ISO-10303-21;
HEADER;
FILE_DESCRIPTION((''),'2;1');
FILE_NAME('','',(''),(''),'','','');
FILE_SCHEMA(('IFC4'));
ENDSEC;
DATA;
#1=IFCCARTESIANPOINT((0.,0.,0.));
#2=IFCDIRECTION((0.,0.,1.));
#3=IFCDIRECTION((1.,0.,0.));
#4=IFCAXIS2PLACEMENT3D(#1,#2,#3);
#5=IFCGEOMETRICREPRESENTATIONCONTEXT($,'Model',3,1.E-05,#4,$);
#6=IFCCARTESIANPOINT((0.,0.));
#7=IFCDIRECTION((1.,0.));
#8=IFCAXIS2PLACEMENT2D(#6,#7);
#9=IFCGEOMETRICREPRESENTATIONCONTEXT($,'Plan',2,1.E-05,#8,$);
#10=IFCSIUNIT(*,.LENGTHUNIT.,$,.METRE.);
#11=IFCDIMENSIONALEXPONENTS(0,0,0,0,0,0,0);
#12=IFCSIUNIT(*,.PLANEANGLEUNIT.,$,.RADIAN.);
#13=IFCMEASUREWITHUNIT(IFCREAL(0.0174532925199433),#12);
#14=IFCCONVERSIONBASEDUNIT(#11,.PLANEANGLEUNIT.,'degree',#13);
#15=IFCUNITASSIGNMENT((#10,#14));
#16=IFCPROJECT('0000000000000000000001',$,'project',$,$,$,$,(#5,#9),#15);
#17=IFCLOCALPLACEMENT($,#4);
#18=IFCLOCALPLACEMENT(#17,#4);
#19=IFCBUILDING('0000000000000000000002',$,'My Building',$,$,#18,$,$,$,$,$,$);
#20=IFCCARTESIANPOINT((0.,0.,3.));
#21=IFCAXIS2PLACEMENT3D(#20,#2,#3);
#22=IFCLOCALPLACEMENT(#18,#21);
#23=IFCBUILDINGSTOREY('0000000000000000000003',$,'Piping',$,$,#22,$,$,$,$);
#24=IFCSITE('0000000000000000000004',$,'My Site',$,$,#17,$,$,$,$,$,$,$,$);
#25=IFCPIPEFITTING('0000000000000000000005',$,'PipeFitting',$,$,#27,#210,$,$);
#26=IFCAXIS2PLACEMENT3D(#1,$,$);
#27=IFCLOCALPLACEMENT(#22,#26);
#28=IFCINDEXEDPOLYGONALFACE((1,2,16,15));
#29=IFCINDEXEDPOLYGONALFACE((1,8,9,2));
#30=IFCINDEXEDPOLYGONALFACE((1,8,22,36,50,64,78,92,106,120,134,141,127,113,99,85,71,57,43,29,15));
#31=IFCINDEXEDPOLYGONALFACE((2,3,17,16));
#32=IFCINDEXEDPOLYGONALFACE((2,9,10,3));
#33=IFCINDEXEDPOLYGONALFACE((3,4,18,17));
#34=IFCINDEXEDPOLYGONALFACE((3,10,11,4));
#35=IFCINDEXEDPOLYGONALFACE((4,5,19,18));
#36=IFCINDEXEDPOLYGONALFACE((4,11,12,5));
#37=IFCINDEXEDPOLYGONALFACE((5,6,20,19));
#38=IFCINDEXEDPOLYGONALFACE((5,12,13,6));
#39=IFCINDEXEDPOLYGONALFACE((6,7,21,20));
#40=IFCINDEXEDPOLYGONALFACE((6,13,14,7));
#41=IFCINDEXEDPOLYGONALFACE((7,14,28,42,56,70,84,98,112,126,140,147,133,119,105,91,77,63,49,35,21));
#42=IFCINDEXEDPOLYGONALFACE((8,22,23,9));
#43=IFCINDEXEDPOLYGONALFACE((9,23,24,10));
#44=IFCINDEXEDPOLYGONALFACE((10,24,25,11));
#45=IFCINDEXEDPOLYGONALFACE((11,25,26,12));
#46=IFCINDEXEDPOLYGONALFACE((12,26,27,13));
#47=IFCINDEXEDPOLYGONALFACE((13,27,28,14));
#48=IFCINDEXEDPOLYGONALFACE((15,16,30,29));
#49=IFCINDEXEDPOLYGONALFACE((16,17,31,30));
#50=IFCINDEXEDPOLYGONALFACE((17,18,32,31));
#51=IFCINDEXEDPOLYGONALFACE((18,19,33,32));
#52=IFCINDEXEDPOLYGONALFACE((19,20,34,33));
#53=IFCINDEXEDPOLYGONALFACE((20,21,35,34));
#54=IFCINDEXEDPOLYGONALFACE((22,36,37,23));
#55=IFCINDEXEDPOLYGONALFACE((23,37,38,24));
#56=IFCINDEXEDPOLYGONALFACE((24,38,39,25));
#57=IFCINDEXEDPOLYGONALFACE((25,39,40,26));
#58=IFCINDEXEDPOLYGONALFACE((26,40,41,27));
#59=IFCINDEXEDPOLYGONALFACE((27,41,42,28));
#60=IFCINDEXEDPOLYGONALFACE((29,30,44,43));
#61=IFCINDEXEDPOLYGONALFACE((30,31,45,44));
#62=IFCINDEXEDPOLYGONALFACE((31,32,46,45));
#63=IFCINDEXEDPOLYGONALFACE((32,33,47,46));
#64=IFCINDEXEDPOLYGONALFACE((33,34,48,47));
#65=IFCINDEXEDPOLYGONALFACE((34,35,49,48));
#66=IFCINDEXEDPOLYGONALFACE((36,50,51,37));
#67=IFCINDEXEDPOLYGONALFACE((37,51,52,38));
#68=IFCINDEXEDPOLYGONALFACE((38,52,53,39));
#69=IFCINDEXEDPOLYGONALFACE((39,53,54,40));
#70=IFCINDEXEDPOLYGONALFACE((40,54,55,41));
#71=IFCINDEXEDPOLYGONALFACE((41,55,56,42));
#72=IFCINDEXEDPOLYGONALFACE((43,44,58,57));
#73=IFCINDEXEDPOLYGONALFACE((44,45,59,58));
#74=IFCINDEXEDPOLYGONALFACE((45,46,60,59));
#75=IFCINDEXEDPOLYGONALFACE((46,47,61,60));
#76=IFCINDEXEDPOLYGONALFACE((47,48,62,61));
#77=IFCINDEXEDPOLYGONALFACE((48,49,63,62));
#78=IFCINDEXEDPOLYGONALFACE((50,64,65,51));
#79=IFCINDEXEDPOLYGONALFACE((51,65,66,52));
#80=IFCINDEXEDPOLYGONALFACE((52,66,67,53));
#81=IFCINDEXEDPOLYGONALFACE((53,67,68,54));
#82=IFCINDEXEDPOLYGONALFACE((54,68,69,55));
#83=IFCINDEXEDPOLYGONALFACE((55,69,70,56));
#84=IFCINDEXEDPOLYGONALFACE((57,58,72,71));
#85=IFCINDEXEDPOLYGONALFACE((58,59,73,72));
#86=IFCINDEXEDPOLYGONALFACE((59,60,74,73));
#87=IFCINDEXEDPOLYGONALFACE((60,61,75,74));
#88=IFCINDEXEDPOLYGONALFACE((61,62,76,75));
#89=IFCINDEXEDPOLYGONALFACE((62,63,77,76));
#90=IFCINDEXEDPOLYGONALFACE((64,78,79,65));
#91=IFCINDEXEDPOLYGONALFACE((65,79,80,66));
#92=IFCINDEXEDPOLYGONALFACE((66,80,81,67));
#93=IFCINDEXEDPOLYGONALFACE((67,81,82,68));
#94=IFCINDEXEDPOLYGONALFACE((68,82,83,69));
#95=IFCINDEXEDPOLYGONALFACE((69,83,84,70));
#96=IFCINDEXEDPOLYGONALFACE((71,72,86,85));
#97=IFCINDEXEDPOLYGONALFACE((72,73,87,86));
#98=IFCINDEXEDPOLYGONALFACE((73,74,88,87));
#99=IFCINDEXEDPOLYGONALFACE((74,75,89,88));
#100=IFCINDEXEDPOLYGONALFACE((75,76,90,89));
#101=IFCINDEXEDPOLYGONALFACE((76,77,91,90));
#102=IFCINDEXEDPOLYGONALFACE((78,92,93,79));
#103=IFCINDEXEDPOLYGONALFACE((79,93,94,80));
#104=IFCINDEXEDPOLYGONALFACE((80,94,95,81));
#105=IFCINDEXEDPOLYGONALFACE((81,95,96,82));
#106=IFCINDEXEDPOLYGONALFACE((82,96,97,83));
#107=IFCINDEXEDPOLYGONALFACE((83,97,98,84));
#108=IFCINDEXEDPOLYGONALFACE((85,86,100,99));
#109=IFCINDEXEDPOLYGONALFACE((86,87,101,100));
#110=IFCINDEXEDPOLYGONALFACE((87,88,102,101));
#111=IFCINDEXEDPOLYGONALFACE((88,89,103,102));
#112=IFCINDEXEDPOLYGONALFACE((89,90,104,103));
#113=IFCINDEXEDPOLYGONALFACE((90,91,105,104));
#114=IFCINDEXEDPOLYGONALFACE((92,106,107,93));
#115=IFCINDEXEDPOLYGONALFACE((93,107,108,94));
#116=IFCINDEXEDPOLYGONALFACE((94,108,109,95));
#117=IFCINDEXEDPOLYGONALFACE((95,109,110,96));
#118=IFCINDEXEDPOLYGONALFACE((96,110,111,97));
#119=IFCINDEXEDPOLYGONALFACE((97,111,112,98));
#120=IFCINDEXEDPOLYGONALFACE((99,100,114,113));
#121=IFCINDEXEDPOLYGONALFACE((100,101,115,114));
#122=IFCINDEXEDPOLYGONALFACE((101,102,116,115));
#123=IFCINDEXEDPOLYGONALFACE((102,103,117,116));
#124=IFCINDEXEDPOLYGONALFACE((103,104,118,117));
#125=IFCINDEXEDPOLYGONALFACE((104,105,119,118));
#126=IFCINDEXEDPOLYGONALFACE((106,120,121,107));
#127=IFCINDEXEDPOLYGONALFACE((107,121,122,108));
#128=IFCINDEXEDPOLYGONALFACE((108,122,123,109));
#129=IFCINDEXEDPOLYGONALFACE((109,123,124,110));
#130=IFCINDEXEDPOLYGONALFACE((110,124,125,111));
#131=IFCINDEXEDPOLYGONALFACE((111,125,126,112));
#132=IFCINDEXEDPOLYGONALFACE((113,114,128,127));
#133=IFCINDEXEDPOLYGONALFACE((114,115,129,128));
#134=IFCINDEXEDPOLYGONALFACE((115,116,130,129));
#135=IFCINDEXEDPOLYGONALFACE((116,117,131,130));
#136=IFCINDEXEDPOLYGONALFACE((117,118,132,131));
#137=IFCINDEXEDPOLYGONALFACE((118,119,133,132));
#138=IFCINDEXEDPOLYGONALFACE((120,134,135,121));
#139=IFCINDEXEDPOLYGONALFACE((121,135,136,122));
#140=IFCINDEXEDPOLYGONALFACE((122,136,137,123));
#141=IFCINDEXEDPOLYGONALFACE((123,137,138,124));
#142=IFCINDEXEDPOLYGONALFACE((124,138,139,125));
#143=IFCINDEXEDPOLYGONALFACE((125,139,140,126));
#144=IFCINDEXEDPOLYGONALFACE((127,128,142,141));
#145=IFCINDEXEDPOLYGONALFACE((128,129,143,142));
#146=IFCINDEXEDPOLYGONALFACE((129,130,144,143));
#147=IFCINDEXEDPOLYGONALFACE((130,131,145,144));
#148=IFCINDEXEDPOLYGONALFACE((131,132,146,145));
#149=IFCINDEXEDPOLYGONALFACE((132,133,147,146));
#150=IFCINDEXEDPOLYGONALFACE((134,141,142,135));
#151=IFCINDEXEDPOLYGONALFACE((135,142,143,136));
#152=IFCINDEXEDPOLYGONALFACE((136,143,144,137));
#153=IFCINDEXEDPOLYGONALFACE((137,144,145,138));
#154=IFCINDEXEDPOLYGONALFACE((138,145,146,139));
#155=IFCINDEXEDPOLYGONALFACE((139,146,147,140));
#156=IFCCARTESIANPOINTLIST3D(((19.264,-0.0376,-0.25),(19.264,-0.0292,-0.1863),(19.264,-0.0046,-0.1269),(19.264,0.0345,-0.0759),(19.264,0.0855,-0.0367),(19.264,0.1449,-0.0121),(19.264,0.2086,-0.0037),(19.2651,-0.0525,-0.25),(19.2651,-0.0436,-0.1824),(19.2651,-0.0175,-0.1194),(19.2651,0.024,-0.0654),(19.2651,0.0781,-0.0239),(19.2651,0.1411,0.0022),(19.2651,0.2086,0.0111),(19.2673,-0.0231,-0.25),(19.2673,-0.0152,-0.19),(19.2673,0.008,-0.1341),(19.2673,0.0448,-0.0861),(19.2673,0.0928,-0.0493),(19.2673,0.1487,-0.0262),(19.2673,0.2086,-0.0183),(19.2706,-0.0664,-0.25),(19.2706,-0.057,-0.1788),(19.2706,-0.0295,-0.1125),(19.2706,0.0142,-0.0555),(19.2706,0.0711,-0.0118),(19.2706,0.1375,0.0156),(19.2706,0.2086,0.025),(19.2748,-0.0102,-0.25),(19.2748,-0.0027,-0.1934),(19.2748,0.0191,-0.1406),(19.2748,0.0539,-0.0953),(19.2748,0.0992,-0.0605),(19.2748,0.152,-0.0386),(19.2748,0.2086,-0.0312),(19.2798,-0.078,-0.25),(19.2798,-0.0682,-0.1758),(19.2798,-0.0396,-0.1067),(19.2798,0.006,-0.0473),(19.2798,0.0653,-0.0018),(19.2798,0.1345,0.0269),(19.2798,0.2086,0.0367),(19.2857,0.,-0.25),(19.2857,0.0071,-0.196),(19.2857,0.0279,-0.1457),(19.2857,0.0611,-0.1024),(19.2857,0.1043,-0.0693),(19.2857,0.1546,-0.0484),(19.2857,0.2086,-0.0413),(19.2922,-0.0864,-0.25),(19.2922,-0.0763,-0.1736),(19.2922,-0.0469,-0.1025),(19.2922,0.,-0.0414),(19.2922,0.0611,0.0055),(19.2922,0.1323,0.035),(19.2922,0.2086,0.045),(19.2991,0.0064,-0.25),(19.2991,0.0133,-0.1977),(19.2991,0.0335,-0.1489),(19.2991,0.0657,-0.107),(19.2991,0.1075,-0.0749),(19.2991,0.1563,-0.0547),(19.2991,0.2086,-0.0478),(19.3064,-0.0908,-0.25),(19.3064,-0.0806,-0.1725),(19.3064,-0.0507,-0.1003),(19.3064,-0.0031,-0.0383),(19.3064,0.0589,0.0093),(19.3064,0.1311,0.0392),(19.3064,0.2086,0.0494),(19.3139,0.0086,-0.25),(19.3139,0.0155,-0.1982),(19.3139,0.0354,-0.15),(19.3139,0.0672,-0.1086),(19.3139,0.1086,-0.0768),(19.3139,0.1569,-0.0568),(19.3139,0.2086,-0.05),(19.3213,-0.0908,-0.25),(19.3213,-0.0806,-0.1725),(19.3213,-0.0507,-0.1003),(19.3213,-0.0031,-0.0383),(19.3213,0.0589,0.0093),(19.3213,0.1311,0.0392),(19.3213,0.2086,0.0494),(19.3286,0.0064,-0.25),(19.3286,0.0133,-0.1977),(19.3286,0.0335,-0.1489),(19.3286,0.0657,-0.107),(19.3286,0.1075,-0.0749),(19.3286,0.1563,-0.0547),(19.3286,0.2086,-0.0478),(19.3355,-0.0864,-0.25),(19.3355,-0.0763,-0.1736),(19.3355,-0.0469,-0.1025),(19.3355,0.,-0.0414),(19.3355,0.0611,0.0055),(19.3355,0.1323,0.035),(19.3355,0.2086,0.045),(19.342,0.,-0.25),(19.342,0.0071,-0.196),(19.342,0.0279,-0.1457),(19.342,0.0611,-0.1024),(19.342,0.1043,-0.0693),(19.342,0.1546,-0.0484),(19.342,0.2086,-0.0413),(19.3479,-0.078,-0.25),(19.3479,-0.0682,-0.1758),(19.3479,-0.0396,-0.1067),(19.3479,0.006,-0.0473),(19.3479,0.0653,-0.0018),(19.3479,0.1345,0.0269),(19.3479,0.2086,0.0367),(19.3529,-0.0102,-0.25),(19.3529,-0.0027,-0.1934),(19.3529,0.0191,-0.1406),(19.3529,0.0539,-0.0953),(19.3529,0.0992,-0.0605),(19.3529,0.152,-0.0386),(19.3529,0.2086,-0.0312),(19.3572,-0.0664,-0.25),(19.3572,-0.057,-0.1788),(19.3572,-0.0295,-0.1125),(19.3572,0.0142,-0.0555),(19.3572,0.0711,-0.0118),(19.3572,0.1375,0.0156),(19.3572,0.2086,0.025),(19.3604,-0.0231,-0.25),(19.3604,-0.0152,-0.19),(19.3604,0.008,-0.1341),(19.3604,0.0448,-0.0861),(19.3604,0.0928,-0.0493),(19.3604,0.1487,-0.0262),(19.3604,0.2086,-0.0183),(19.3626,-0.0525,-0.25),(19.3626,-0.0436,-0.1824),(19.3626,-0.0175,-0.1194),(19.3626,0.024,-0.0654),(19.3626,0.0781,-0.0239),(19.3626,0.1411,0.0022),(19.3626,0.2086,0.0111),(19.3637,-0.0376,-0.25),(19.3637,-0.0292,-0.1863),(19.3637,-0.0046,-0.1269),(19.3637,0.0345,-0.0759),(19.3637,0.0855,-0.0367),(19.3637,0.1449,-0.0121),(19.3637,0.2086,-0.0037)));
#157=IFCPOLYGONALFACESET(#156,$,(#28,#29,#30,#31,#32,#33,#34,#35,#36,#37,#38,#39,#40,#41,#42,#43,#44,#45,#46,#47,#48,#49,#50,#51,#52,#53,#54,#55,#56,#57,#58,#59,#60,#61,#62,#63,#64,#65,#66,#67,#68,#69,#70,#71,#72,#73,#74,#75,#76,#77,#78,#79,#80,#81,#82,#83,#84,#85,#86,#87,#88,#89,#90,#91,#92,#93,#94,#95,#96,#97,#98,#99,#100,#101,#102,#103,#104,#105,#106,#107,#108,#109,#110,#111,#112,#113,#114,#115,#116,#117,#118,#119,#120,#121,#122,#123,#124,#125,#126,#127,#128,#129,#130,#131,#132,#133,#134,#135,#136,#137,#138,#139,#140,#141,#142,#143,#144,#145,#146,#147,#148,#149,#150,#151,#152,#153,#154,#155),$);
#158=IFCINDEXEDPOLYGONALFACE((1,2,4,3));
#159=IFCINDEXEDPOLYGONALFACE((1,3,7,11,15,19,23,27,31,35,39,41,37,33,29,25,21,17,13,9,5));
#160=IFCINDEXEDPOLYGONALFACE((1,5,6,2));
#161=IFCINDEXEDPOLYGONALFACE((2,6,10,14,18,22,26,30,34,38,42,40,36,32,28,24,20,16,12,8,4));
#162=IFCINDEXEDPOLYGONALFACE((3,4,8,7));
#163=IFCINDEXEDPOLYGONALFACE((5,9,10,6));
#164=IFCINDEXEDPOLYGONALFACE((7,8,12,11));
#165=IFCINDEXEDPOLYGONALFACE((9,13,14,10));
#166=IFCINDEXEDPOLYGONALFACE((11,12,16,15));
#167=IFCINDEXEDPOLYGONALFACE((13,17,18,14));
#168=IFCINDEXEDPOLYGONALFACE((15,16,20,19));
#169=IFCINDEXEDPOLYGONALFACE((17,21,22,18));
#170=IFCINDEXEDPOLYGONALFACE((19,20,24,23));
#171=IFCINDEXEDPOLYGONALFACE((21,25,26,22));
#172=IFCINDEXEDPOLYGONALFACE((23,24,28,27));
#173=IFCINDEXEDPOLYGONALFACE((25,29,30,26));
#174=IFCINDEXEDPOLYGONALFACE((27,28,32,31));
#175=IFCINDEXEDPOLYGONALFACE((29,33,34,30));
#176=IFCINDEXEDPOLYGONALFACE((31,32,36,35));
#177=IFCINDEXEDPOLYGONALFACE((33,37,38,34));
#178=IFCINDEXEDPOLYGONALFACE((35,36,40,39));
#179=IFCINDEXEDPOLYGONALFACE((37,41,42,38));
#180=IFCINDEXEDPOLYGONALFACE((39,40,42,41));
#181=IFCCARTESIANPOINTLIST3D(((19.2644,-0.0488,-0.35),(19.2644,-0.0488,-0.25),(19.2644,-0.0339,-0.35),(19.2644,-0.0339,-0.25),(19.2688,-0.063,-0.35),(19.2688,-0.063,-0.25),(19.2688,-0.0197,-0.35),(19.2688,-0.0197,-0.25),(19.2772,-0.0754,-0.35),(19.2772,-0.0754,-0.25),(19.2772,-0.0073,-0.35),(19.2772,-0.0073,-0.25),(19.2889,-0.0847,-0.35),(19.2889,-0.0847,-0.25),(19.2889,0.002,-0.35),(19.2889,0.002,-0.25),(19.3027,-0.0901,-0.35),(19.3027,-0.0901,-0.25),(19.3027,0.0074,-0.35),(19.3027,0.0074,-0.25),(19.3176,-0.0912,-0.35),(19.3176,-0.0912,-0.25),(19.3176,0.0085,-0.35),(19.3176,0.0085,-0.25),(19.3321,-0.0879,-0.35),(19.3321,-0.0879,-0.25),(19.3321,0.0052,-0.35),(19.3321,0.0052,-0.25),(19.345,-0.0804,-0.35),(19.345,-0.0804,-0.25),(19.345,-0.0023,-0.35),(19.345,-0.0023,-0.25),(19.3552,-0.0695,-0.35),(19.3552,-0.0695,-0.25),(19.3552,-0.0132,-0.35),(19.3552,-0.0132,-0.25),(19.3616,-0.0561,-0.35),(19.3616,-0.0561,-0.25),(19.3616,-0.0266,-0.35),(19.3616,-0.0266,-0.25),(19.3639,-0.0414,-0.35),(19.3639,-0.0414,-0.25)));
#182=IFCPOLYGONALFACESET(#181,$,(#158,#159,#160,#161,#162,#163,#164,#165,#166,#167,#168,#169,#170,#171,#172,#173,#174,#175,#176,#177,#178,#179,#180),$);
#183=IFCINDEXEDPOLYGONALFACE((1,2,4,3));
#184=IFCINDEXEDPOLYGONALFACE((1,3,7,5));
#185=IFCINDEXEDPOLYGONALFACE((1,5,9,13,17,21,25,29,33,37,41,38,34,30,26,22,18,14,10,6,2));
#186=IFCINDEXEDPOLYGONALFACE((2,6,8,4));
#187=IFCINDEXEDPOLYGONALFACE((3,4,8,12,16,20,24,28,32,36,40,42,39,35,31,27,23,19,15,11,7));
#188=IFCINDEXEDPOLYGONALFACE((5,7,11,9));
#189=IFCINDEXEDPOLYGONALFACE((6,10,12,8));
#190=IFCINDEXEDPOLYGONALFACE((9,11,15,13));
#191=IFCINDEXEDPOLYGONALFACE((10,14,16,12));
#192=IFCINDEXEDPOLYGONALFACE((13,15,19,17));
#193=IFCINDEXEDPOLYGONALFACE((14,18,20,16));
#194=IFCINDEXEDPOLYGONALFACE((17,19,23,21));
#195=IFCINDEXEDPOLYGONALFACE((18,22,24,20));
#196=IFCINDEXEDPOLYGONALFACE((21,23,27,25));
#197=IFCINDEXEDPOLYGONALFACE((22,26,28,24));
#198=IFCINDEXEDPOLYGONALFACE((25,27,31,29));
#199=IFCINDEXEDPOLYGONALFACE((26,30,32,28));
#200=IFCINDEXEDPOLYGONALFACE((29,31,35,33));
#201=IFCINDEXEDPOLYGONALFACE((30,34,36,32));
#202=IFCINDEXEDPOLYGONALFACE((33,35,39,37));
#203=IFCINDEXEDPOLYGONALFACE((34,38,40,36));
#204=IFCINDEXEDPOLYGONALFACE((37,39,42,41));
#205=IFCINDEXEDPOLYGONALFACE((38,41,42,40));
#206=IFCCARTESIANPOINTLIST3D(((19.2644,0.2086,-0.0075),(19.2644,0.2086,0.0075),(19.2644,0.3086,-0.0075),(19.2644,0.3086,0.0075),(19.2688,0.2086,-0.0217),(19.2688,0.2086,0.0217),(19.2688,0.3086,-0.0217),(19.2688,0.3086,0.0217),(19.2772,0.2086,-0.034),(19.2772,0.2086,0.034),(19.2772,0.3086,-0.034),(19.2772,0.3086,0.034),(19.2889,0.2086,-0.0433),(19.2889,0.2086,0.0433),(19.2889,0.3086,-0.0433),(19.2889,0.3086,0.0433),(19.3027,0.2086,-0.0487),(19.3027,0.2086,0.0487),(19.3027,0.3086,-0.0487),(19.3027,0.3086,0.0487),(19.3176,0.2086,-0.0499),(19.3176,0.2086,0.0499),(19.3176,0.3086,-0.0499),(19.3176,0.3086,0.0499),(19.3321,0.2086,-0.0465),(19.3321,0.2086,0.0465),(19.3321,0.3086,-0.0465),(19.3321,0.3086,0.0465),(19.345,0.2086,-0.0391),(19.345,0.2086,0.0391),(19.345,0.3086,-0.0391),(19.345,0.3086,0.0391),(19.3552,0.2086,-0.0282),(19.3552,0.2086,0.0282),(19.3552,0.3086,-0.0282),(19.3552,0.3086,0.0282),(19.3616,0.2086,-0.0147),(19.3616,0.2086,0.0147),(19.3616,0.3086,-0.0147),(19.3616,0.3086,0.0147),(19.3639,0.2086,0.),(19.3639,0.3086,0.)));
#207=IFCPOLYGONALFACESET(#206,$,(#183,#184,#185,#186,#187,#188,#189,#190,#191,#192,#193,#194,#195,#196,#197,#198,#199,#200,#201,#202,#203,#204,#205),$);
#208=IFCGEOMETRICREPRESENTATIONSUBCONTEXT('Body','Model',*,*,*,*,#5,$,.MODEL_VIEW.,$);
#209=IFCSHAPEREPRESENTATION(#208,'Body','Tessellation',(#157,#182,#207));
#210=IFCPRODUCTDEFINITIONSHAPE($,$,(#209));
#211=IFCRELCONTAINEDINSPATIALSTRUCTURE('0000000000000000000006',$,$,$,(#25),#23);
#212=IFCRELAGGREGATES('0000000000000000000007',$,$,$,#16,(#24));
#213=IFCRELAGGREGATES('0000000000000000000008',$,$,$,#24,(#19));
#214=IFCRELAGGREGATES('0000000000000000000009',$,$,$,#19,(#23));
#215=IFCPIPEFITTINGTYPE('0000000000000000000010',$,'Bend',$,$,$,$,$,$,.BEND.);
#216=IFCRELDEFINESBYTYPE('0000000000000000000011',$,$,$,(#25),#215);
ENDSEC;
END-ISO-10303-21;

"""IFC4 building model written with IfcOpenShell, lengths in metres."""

from ifc_helpers import new_model, entity, si_unit, converted_unit, frame, origin_with_axes, origin_2d_with_axis, place, context, subcontext, project, spatial, circle, extrude, source, transform, mapped, type_object, type_shapes, element, save


model = new_model("IFC4")

# Units and contexts
model_context = context("Model", 3, precision=1e-05, world=origin_with_axes())
plan_context = context("Plan", 2, precision=1e-05, world=origin_2d_with_axis())
body_context = subcontext(model_context, "Body", "Model", "MODEL_VIEW")
ifc_project = project(units=[si_unit("LENGTHUNIT", "METRE"), converted_unit("PLANEANGLEUNIT", "degree", entity("IfcReal", 0.0174532925199433), si_unit("PLANEANGLEUNIT", "RADIAN"), dimensions=[0, 0, 0, 0, 0, 0, 0])], contexts=[model_context, plan_context])

# Site, building, storey
site_placement = place(None, origin_with_axes())
site = spatial("IfcSite", under=ifc_project, at=site_placement, Name="My Site")
building_placement = place(site_placement, origin_with_axes())
building = spatial("IfcBuilding", under=site, at=building_placement, Name="My Building")
storey_placement = place(building_placement, frame((0.0, 0.0, 3.0), z_axis=(0.0, 0.0, 1.0), x_axis=(1.0, 0.0, 0.0)))
storey = spatial("IfcBuildingStorey", under=building, at=storey_placement, Name="Piping")

# Shared definitions
pipe_fitting_type = type_object("IfcPipeFittingType", Name="Bend", PredefinedType="BEND")
shared_shape = source(origin_with_axes(), body_context, "Body", "SolidModel", [
    entity("IfcSweptDiskSolid", entity("IfcIndexedPolyCurve", entity("IfcCartesianPointList3D", [[0.0, 0.0, -0.1], [0.0, -0.0732, -0.2768], [0.0, -0.25, -0.35]]), [entity("IfcArcIndex", [1, 2, 3])]), 0.05),
    extrude(circle(Radius=0.05), origin_with_axes(), (0.0, 0.0, -1.0), 0.1),
    extrude(circle(Radius=0.05), frame((0.0, -0.25, -0.35), z_axis=(0.0, -1.0, 0.0), x_axis=(1.0, 0.0, 0.0)), (0.0, 0.0, 1.0), 0.1),
])
type_shapes(pipe_fitting_type, [shared_shape])

# Pipe fitting
for number, where, z_axis, x_axis, name in (
    (1, (19.3139, -0.0414, -0.35), (0.0, 0.0, -1.0), (1.0, 0.0, 0.0), "PipeFitting"),
):
    element("IfcPipeFitting", number, at=place(storey_placement, frame(where, z_axis=z_axis, x_axis=x_axis)), inside=storey, type_object=pipe_fitting_type, Name=name, context=body_context, shape_type="MappedRepresentation", body=[
        mapped(shared_shape, transform((0.0, 0.0, 0.0), x_axis=(1.0, 0.0, 0.0), y_axis=(0.0, 1.0, 0.0), z_axis=(0.0, 0.0, 1.0), scale=1.0)),
    ])

save(model, "model.ifc")
